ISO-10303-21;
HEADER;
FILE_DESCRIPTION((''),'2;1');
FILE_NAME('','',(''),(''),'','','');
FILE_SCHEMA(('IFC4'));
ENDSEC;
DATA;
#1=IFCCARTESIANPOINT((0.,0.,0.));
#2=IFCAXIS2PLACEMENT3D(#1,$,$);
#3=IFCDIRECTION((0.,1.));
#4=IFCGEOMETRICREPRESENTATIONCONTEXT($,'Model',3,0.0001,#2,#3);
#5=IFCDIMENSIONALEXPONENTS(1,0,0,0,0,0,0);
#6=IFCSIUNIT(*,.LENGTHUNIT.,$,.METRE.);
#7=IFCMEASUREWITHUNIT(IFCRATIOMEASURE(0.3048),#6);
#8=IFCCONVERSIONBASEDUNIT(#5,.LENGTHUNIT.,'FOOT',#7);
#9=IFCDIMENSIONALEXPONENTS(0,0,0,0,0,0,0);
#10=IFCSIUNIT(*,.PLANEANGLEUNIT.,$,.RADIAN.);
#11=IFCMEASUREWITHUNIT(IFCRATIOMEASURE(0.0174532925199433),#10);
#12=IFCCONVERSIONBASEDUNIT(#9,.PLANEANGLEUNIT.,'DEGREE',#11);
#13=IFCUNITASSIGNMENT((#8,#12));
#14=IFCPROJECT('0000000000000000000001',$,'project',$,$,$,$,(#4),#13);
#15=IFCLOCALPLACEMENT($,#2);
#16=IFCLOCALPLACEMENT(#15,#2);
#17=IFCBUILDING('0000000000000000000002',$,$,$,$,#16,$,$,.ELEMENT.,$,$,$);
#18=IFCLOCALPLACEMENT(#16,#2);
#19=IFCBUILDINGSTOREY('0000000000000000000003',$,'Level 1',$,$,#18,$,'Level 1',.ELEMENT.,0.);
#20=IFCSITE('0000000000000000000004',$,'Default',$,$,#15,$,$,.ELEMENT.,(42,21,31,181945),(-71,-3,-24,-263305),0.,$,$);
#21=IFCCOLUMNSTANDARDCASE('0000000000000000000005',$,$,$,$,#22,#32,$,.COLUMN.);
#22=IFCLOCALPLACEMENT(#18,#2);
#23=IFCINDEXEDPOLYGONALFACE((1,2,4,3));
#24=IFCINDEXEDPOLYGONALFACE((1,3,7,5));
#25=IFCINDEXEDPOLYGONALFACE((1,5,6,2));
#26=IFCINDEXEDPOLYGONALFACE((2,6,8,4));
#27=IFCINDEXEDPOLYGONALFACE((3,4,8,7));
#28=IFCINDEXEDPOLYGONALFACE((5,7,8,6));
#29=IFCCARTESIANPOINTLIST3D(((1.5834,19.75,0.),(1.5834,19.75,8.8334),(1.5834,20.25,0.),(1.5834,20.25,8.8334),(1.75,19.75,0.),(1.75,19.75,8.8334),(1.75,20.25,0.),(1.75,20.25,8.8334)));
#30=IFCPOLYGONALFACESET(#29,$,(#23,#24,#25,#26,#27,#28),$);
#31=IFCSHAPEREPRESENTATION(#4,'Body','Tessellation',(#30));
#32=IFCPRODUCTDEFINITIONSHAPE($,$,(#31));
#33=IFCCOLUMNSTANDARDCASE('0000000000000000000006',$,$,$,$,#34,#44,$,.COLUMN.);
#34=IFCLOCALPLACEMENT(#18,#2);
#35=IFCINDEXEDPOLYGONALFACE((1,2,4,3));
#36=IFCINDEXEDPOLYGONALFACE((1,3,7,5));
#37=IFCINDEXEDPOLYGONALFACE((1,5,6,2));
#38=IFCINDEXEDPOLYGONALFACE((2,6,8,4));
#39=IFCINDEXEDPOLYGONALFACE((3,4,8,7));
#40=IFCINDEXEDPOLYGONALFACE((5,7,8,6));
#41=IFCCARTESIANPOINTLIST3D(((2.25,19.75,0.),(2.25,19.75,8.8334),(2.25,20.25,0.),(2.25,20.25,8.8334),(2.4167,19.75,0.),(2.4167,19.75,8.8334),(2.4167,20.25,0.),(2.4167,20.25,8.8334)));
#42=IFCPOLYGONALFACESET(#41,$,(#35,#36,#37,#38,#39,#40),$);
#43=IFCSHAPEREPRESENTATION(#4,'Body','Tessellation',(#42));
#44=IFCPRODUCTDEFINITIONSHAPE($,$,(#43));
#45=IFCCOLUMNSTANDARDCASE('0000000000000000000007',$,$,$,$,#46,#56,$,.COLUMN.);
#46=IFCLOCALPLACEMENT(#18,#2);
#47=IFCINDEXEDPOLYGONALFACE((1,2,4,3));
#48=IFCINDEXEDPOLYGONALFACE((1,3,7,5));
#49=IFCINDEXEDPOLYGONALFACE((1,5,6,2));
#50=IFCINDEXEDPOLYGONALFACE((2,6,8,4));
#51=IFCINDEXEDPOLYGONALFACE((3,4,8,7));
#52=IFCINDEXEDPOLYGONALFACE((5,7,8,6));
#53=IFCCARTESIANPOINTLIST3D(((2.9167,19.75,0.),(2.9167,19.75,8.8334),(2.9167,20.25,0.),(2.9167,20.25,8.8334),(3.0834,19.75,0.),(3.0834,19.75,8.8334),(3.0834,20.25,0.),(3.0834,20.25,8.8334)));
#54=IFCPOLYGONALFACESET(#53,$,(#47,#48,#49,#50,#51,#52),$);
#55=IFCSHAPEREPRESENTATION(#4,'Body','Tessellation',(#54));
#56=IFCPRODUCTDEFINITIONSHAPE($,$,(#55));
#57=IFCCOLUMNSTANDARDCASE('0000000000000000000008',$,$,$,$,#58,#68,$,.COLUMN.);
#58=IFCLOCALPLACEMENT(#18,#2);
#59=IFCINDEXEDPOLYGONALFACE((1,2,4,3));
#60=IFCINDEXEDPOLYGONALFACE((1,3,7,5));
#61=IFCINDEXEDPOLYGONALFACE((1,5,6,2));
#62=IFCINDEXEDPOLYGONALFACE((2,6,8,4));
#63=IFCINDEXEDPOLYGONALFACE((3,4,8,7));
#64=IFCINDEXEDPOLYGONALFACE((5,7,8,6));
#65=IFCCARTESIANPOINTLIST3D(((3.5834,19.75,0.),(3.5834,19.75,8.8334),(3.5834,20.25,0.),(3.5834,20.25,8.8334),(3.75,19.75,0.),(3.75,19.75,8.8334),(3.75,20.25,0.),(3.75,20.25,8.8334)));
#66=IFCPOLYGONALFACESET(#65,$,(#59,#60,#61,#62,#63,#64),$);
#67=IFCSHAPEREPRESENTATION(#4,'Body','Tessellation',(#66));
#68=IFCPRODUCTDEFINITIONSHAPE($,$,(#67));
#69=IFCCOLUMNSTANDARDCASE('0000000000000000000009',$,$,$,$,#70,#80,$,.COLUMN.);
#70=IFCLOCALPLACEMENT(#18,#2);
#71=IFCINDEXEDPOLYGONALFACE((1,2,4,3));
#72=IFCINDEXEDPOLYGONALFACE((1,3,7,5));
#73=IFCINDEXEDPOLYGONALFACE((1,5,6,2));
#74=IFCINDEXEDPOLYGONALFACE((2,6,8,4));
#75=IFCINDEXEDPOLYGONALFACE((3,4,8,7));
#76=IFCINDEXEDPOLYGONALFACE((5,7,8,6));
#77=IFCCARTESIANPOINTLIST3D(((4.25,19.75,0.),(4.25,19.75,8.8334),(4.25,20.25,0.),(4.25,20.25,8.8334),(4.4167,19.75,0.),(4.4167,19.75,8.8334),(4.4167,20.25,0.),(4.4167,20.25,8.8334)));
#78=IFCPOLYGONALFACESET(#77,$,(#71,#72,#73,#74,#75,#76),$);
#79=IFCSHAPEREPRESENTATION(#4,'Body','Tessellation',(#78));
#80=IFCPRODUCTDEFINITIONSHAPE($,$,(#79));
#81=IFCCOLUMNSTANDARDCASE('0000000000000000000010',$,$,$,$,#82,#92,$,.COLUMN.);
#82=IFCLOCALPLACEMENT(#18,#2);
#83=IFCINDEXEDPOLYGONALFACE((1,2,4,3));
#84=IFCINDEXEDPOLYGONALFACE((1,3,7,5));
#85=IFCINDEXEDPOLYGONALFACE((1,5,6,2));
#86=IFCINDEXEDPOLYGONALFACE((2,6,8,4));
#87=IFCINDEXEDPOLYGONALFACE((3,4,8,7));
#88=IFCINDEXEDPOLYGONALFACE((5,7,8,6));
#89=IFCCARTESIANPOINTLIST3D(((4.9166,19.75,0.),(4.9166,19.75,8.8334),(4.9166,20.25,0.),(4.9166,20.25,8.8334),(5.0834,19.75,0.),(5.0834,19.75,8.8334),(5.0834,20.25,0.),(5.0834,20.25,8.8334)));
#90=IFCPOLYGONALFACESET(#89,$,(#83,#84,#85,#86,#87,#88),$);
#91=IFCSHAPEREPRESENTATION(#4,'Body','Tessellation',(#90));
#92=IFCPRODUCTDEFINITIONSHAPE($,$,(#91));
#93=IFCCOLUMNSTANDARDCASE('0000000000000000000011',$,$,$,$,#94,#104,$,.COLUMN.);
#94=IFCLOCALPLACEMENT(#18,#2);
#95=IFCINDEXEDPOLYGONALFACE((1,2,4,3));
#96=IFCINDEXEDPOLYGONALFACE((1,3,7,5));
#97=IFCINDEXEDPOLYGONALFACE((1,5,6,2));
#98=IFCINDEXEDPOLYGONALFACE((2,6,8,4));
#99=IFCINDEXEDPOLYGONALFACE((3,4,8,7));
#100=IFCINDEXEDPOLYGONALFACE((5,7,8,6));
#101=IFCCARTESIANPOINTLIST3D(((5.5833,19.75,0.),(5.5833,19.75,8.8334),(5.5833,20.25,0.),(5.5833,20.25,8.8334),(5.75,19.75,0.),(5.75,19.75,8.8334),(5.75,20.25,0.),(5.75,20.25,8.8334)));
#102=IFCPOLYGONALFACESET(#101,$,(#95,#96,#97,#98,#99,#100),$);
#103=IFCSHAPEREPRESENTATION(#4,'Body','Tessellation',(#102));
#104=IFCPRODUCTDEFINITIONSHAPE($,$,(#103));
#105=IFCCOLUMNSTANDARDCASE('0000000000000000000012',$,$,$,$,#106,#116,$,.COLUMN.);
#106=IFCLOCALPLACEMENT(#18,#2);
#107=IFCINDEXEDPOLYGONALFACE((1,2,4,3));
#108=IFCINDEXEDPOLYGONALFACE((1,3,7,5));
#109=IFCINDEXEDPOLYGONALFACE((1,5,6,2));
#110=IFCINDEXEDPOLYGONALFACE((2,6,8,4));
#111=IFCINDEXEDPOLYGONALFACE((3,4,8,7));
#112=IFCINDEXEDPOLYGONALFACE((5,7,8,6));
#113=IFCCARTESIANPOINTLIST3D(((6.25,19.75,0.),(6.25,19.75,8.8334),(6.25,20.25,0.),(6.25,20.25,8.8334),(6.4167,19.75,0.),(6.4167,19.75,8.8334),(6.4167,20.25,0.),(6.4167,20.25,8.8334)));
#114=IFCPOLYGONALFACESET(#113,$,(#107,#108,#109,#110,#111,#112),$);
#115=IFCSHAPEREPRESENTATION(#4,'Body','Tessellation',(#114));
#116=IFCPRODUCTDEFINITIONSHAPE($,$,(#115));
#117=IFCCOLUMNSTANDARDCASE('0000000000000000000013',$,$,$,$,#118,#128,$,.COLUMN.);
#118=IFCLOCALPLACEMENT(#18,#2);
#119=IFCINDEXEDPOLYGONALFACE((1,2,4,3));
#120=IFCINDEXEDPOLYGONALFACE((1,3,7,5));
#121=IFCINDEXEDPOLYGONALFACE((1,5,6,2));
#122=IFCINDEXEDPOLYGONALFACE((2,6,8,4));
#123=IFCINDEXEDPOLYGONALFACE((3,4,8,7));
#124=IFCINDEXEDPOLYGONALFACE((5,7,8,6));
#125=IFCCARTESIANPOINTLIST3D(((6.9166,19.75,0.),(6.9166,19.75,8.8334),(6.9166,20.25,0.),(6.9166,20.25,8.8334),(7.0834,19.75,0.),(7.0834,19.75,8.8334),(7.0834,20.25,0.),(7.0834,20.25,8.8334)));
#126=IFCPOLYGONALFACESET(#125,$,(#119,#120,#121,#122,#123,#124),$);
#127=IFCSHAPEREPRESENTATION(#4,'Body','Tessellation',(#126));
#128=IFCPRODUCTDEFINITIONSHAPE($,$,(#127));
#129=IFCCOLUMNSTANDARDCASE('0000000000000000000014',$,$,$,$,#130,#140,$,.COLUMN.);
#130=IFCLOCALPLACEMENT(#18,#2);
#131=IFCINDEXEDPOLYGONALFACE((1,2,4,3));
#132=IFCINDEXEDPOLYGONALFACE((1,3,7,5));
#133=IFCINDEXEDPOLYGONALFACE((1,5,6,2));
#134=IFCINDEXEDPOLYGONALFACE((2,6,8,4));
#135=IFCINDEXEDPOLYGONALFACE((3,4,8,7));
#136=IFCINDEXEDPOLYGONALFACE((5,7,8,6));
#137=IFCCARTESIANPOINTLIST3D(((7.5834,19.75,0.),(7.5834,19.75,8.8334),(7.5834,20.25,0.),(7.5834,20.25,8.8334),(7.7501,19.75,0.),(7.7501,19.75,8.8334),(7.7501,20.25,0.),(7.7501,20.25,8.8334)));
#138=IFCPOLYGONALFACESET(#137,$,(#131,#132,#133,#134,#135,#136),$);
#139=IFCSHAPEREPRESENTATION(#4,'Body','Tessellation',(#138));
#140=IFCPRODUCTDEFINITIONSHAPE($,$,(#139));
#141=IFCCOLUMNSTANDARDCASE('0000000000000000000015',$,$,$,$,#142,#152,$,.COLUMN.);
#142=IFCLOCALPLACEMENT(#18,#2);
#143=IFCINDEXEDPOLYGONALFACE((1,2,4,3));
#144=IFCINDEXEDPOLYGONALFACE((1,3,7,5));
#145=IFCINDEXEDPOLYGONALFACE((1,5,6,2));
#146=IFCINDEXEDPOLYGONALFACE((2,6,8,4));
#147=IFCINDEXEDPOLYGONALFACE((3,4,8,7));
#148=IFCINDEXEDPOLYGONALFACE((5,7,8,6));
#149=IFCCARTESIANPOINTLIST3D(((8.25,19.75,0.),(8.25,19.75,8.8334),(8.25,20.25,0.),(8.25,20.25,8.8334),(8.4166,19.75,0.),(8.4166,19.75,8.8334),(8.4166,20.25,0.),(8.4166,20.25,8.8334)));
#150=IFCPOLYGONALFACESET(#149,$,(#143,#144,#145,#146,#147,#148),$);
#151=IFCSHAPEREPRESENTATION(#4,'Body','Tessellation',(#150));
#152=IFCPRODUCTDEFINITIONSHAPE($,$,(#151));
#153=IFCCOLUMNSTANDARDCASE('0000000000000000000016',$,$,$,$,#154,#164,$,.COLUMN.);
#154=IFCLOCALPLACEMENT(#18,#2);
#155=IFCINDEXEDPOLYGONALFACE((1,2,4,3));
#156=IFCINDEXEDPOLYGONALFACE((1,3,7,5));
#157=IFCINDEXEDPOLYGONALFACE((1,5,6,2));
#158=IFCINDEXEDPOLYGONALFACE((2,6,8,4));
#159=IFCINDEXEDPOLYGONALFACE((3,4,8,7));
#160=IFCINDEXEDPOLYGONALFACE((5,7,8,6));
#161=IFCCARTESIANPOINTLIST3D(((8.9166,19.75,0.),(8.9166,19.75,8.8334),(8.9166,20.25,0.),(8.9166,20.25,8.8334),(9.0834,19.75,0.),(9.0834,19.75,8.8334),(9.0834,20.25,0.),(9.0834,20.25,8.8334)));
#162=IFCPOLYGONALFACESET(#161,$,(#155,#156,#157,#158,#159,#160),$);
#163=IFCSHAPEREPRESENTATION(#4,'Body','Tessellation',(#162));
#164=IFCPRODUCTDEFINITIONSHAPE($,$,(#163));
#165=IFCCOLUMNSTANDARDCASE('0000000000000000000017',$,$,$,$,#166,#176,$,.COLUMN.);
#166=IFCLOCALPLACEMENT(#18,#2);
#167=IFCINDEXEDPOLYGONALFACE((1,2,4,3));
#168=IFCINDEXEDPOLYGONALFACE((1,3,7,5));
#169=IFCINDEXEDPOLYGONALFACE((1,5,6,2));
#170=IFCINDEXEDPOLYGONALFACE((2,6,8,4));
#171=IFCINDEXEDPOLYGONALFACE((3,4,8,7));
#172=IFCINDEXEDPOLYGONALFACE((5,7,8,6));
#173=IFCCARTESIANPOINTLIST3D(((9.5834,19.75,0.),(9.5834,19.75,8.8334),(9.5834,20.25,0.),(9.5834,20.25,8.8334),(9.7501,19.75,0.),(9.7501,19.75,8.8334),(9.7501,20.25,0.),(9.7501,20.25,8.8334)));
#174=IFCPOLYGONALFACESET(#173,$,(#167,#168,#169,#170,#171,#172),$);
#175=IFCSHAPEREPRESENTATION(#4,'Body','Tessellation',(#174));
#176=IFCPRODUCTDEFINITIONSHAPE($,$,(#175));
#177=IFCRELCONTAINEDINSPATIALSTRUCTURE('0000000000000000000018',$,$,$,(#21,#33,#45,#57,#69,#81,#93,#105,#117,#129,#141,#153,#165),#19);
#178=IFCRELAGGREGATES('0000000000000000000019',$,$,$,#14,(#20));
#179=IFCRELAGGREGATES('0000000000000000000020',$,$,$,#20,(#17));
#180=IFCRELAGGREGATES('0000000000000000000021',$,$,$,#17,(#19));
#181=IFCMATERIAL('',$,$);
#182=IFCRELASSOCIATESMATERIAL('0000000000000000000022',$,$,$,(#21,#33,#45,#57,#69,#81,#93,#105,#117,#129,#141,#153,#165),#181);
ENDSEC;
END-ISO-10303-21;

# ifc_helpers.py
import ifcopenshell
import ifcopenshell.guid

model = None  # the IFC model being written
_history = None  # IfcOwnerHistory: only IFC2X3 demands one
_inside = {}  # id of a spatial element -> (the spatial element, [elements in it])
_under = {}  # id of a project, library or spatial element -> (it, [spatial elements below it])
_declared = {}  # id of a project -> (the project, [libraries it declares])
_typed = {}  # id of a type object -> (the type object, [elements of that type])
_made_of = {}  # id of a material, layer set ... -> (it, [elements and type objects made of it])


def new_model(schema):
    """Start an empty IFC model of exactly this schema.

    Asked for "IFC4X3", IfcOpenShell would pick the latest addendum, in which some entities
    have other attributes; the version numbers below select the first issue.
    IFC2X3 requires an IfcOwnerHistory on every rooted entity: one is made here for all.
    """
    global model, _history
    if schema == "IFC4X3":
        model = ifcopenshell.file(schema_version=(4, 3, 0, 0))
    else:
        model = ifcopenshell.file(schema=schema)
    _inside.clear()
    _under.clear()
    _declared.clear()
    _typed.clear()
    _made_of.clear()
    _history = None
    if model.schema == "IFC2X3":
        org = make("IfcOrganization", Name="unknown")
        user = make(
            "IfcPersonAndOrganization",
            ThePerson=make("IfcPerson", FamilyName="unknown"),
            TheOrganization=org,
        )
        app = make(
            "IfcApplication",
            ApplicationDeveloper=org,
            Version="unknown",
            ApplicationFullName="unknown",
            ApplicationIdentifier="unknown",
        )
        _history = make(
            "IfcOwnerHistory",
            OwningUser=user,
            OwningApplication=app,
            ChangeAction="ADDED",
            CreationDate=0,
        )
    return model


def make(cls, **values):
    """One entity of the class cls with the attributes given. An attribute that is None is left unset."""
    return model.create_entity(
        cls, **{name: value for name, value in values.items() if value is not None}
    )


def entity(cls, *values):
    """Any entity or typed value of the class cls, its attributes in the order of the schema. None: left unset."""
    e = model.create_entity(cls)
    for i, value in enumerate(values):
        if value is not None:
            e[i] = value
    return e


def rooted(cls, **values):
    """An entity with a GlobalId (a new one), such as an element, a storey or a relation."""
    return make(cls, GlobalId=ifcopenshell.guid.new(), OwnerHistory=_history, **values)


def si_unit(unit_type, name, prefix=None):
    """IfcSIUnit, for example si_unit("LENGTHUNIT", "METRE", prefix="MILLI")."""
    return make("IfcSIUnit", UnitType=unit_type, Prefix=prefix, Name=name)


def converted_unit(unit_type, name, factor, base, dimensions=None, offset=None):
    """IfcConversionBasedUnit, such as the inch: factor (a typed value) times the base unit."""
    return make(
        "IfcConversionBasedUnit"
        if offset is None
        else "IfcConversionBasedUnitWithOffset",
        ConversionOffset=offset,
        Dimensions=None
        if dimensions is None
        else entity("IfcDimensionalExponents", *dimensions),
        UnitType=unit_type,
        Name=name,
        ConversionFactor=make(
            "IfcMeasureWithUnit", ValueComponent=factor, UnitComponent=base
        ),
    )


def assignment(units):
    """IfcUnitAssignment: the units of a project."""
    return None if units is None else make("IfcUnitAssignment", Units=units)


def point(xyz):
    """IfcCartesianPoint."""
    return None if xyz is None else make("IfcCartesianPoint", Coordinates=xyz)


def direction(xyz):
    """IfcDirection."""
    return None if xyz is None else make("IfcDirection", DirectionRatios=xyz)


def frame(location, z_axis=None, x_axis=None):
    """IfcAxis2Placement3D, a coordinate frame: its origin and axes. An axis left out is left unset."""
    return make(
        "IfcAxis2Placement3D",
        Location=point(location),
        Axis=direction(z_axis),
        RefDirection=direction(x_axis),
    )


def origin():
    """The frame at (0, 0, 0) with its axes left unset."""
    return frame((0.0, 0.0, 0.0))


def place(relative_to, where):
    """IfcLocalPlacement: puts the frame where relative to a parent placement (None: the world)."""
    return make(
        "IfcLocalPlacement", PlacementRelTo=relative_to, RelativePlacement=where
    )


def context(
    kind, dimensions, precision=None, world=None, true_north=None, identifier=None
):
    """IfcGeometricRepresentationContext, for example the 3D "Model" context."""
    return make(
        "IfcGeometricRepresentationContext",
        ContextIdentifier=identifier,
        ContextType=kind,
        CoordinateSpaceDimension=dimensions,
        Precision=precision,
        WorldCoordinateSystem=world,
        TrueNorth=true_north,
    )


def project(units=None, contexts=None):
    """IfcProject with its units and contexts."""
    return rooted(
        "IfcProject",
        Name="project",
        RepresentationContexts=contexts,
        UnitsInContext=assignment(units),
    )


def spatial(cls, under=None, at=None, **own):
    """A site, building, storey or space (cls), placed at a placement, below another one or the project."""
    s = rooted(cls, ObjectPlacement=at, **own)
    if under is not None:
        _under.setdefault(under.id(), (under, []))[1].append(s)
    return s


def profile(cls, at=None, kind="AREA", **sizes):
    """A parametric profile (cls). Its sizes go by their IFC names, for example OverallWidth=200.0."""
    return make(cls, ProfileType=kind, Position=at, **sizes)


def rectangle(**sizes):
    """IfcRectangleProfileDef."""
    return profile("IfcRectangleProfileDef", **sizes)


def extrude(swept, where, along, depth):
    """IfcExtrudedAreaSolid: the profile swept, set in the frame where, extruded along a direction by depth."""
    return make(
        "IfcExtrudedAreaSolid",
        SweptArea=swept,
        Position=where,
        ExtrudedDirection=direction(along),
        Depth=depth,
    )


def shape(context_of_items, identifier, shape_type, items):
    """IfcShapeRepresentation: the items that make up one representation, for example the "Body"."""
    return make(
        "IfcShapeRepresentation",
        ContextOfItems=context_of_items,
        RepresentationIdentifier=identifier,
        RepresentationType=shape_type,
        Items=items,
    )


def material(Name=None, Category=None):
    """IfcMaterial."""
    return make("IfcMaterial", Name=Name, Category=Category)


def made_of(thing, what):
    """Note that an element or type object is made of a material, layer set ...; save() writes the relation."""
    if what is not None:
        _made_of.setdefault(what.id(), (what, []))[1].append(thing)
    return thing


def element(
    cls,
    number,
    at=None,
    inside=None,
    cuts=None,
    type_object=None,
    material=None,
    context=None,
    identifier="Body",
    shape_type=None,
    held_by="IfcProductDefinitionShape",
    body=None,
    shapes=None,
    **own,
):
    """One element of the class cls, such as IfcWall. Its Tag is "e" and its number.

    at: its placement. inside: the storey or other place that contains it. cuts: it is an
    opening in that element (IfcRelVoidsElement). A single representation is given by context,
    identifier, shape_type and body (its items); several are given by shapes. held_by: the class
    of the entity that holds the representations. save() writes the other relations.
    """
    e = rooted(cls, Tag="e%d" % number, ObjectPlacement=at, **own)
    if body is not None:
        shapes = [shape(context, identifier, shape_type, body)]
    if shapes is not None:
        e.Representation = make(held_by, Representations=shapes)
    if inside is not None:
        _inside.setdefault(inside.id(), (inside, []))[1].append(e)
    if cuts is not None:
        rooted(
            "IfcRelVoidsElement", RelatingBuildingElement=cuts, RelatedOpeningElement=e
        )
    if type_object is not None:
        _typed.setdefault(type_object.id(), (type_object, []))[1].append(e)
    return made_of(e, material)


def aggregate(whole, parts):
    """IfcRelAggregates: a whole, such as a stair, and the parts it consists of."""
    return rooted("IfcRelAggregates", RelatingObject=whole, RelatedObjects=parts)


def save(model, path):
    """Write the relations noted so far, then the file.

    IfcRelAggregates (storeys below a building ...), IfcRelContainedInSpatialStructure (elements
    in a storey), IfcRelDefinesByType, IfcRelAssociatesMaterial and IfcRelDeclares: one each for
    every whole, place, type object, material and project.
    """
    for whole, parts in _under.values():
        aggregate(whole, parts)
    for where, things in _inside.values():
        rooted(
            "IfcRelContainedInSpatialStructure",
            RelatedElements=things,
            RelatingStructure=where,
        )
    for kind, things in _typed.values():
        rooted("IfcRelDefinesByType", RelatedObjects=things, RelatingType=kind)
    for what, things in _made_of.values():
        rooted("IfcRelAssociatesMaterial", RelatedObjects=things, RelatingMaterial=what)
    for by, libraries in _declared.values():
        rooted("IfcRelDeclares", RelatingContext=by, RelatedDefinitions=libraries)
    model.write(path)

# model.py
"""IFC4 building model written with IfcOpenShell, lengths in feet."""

from ifc_helpers import new_model, entity, si_unit, converted_unit, direction, frame, origin, place, context, project, spatial, rectangle, extrude, material, element, save


model = new_model("IFC4")

# Units and contexts
model_context = context("Model", 3, precision=0.0001, world=origin(), true_north=direction((0.0, 1.0)))
ifc_project = project(units=[converted_unit("LENGTHUNIT", "FOOT", entity("IfcRatioMeasure", 0.3048), si_unit("LENGTHUNIT", "METRE"), dimensions=[1, 0, 0, 0, 0, 0, 0]), converted_unit("PLANEANGLEUNIT", "DEGREE", entity("IfcRatioMeasure", 0.0174532925199433), si_unit("PLANEANGLEUNIT", "RADIAN"), dimensions=[0, 0, 0, 0, 0, 0, 0])], contexts=[model_context])

# Site, building, storey
site_placement = place(None, origin())
site = spatial("IfcSite", under=ifc_project, at=site_placement, Name="Default", CompositionType="ELEMENT", RefLatitude=(42, 21, 31, 181945), RefLongitude=(-71, -3, -24, -263305), RefElevation=0.0)
building_placement = place(site_placement, origin())
building = spatial("IfcBuilding", under=site, at=building_placement, CompositionType="ELEMENT")
storey_placement = place(building_placement, origin())
storey = spatial("IfcBuildingStorey", under=building, at=storey_placement, Name="Level 1", LongName="Level 1", CompositionType="ELEMENT", Elevation=0.0)

# Columns
ifc_material_1 = material(Name="")
placement_1 = place(storey_placement, frame((0.25, 20.0, 0.0)))
for number, where, z_axis, x_axis in (
    (1, (1.4167, 0.0, 0.0), (0.0, 0.0, 1.0), (1.0, 0.0, 0.0)),
    (2, (2.0833, 0.0, 0.0), (0.0, 0.0, 1.0), (1.0, 0.0, 0.0)),
    (3, (2.75, 0.0, 0.0), (0.0, 0.0, 1.0), (1.0, 0.0, 0.0)),
    (4, (3.4167, 0.0, 0.0), (0.0, 0.0, 1.0), (1.0, 0.0, 0.0)),
    (5, (4.0833, 0.0, 0.0), (0.0, 0.0, 1.0), (1.0, 0.0, 0.0)),
    (6, (4.75, 0.0, 0.0), (0.0, 0.0, 1.0), (1.0, 0.0, 0.0)),
    (7, (5.4167, 0.0, 0.0), (0.0, 0.0, 1.0), (1.0, 0.0, 0.0)),
    (8, (6.0833, 0.0, 0.0), (0.0, 0.0, 1.0), (1.0, 0.0, 0.0)),
    (9, (6.75, 0.0, 0.0), (0.0, 0.0, 1.0), (1.0, 0.0, 0.0)),
    (10, (7.4167, 0.0, 0.0), (0.0, 0.0, 1.0), (1.0, 0.0, 0.0)),
    (11, (8.0833, 0.0, 0.0), (0.0, 0.0, 1.0), (1.0, 0.0, 0.0)),
    (12, (8.75, 0.0, 0.0), (0.0, 0.0, 1.0), (1.0, 0.0, 0.0)),
    (13, (9.4167, 0.0, 0.0), (0.0, 0.0, 1.0), (1.0, 0.0, 0.0)),
):
    element("IfcColumnStandardCase", number, at=place(placement_1, frame(where, z_axis=z_axis, x_axis=x_axis)), inside=storey, material=ifc_material_1, PredefinedType="COLUMN", context=model_context, shape_type="SweptSolid", body=[
        extrude(rectangle(XDim=0.1667, YDim=0.5), origin(), (0.0, 0.0, 1.0), 8.8334),
    ])

save(model, "model.ifc")
